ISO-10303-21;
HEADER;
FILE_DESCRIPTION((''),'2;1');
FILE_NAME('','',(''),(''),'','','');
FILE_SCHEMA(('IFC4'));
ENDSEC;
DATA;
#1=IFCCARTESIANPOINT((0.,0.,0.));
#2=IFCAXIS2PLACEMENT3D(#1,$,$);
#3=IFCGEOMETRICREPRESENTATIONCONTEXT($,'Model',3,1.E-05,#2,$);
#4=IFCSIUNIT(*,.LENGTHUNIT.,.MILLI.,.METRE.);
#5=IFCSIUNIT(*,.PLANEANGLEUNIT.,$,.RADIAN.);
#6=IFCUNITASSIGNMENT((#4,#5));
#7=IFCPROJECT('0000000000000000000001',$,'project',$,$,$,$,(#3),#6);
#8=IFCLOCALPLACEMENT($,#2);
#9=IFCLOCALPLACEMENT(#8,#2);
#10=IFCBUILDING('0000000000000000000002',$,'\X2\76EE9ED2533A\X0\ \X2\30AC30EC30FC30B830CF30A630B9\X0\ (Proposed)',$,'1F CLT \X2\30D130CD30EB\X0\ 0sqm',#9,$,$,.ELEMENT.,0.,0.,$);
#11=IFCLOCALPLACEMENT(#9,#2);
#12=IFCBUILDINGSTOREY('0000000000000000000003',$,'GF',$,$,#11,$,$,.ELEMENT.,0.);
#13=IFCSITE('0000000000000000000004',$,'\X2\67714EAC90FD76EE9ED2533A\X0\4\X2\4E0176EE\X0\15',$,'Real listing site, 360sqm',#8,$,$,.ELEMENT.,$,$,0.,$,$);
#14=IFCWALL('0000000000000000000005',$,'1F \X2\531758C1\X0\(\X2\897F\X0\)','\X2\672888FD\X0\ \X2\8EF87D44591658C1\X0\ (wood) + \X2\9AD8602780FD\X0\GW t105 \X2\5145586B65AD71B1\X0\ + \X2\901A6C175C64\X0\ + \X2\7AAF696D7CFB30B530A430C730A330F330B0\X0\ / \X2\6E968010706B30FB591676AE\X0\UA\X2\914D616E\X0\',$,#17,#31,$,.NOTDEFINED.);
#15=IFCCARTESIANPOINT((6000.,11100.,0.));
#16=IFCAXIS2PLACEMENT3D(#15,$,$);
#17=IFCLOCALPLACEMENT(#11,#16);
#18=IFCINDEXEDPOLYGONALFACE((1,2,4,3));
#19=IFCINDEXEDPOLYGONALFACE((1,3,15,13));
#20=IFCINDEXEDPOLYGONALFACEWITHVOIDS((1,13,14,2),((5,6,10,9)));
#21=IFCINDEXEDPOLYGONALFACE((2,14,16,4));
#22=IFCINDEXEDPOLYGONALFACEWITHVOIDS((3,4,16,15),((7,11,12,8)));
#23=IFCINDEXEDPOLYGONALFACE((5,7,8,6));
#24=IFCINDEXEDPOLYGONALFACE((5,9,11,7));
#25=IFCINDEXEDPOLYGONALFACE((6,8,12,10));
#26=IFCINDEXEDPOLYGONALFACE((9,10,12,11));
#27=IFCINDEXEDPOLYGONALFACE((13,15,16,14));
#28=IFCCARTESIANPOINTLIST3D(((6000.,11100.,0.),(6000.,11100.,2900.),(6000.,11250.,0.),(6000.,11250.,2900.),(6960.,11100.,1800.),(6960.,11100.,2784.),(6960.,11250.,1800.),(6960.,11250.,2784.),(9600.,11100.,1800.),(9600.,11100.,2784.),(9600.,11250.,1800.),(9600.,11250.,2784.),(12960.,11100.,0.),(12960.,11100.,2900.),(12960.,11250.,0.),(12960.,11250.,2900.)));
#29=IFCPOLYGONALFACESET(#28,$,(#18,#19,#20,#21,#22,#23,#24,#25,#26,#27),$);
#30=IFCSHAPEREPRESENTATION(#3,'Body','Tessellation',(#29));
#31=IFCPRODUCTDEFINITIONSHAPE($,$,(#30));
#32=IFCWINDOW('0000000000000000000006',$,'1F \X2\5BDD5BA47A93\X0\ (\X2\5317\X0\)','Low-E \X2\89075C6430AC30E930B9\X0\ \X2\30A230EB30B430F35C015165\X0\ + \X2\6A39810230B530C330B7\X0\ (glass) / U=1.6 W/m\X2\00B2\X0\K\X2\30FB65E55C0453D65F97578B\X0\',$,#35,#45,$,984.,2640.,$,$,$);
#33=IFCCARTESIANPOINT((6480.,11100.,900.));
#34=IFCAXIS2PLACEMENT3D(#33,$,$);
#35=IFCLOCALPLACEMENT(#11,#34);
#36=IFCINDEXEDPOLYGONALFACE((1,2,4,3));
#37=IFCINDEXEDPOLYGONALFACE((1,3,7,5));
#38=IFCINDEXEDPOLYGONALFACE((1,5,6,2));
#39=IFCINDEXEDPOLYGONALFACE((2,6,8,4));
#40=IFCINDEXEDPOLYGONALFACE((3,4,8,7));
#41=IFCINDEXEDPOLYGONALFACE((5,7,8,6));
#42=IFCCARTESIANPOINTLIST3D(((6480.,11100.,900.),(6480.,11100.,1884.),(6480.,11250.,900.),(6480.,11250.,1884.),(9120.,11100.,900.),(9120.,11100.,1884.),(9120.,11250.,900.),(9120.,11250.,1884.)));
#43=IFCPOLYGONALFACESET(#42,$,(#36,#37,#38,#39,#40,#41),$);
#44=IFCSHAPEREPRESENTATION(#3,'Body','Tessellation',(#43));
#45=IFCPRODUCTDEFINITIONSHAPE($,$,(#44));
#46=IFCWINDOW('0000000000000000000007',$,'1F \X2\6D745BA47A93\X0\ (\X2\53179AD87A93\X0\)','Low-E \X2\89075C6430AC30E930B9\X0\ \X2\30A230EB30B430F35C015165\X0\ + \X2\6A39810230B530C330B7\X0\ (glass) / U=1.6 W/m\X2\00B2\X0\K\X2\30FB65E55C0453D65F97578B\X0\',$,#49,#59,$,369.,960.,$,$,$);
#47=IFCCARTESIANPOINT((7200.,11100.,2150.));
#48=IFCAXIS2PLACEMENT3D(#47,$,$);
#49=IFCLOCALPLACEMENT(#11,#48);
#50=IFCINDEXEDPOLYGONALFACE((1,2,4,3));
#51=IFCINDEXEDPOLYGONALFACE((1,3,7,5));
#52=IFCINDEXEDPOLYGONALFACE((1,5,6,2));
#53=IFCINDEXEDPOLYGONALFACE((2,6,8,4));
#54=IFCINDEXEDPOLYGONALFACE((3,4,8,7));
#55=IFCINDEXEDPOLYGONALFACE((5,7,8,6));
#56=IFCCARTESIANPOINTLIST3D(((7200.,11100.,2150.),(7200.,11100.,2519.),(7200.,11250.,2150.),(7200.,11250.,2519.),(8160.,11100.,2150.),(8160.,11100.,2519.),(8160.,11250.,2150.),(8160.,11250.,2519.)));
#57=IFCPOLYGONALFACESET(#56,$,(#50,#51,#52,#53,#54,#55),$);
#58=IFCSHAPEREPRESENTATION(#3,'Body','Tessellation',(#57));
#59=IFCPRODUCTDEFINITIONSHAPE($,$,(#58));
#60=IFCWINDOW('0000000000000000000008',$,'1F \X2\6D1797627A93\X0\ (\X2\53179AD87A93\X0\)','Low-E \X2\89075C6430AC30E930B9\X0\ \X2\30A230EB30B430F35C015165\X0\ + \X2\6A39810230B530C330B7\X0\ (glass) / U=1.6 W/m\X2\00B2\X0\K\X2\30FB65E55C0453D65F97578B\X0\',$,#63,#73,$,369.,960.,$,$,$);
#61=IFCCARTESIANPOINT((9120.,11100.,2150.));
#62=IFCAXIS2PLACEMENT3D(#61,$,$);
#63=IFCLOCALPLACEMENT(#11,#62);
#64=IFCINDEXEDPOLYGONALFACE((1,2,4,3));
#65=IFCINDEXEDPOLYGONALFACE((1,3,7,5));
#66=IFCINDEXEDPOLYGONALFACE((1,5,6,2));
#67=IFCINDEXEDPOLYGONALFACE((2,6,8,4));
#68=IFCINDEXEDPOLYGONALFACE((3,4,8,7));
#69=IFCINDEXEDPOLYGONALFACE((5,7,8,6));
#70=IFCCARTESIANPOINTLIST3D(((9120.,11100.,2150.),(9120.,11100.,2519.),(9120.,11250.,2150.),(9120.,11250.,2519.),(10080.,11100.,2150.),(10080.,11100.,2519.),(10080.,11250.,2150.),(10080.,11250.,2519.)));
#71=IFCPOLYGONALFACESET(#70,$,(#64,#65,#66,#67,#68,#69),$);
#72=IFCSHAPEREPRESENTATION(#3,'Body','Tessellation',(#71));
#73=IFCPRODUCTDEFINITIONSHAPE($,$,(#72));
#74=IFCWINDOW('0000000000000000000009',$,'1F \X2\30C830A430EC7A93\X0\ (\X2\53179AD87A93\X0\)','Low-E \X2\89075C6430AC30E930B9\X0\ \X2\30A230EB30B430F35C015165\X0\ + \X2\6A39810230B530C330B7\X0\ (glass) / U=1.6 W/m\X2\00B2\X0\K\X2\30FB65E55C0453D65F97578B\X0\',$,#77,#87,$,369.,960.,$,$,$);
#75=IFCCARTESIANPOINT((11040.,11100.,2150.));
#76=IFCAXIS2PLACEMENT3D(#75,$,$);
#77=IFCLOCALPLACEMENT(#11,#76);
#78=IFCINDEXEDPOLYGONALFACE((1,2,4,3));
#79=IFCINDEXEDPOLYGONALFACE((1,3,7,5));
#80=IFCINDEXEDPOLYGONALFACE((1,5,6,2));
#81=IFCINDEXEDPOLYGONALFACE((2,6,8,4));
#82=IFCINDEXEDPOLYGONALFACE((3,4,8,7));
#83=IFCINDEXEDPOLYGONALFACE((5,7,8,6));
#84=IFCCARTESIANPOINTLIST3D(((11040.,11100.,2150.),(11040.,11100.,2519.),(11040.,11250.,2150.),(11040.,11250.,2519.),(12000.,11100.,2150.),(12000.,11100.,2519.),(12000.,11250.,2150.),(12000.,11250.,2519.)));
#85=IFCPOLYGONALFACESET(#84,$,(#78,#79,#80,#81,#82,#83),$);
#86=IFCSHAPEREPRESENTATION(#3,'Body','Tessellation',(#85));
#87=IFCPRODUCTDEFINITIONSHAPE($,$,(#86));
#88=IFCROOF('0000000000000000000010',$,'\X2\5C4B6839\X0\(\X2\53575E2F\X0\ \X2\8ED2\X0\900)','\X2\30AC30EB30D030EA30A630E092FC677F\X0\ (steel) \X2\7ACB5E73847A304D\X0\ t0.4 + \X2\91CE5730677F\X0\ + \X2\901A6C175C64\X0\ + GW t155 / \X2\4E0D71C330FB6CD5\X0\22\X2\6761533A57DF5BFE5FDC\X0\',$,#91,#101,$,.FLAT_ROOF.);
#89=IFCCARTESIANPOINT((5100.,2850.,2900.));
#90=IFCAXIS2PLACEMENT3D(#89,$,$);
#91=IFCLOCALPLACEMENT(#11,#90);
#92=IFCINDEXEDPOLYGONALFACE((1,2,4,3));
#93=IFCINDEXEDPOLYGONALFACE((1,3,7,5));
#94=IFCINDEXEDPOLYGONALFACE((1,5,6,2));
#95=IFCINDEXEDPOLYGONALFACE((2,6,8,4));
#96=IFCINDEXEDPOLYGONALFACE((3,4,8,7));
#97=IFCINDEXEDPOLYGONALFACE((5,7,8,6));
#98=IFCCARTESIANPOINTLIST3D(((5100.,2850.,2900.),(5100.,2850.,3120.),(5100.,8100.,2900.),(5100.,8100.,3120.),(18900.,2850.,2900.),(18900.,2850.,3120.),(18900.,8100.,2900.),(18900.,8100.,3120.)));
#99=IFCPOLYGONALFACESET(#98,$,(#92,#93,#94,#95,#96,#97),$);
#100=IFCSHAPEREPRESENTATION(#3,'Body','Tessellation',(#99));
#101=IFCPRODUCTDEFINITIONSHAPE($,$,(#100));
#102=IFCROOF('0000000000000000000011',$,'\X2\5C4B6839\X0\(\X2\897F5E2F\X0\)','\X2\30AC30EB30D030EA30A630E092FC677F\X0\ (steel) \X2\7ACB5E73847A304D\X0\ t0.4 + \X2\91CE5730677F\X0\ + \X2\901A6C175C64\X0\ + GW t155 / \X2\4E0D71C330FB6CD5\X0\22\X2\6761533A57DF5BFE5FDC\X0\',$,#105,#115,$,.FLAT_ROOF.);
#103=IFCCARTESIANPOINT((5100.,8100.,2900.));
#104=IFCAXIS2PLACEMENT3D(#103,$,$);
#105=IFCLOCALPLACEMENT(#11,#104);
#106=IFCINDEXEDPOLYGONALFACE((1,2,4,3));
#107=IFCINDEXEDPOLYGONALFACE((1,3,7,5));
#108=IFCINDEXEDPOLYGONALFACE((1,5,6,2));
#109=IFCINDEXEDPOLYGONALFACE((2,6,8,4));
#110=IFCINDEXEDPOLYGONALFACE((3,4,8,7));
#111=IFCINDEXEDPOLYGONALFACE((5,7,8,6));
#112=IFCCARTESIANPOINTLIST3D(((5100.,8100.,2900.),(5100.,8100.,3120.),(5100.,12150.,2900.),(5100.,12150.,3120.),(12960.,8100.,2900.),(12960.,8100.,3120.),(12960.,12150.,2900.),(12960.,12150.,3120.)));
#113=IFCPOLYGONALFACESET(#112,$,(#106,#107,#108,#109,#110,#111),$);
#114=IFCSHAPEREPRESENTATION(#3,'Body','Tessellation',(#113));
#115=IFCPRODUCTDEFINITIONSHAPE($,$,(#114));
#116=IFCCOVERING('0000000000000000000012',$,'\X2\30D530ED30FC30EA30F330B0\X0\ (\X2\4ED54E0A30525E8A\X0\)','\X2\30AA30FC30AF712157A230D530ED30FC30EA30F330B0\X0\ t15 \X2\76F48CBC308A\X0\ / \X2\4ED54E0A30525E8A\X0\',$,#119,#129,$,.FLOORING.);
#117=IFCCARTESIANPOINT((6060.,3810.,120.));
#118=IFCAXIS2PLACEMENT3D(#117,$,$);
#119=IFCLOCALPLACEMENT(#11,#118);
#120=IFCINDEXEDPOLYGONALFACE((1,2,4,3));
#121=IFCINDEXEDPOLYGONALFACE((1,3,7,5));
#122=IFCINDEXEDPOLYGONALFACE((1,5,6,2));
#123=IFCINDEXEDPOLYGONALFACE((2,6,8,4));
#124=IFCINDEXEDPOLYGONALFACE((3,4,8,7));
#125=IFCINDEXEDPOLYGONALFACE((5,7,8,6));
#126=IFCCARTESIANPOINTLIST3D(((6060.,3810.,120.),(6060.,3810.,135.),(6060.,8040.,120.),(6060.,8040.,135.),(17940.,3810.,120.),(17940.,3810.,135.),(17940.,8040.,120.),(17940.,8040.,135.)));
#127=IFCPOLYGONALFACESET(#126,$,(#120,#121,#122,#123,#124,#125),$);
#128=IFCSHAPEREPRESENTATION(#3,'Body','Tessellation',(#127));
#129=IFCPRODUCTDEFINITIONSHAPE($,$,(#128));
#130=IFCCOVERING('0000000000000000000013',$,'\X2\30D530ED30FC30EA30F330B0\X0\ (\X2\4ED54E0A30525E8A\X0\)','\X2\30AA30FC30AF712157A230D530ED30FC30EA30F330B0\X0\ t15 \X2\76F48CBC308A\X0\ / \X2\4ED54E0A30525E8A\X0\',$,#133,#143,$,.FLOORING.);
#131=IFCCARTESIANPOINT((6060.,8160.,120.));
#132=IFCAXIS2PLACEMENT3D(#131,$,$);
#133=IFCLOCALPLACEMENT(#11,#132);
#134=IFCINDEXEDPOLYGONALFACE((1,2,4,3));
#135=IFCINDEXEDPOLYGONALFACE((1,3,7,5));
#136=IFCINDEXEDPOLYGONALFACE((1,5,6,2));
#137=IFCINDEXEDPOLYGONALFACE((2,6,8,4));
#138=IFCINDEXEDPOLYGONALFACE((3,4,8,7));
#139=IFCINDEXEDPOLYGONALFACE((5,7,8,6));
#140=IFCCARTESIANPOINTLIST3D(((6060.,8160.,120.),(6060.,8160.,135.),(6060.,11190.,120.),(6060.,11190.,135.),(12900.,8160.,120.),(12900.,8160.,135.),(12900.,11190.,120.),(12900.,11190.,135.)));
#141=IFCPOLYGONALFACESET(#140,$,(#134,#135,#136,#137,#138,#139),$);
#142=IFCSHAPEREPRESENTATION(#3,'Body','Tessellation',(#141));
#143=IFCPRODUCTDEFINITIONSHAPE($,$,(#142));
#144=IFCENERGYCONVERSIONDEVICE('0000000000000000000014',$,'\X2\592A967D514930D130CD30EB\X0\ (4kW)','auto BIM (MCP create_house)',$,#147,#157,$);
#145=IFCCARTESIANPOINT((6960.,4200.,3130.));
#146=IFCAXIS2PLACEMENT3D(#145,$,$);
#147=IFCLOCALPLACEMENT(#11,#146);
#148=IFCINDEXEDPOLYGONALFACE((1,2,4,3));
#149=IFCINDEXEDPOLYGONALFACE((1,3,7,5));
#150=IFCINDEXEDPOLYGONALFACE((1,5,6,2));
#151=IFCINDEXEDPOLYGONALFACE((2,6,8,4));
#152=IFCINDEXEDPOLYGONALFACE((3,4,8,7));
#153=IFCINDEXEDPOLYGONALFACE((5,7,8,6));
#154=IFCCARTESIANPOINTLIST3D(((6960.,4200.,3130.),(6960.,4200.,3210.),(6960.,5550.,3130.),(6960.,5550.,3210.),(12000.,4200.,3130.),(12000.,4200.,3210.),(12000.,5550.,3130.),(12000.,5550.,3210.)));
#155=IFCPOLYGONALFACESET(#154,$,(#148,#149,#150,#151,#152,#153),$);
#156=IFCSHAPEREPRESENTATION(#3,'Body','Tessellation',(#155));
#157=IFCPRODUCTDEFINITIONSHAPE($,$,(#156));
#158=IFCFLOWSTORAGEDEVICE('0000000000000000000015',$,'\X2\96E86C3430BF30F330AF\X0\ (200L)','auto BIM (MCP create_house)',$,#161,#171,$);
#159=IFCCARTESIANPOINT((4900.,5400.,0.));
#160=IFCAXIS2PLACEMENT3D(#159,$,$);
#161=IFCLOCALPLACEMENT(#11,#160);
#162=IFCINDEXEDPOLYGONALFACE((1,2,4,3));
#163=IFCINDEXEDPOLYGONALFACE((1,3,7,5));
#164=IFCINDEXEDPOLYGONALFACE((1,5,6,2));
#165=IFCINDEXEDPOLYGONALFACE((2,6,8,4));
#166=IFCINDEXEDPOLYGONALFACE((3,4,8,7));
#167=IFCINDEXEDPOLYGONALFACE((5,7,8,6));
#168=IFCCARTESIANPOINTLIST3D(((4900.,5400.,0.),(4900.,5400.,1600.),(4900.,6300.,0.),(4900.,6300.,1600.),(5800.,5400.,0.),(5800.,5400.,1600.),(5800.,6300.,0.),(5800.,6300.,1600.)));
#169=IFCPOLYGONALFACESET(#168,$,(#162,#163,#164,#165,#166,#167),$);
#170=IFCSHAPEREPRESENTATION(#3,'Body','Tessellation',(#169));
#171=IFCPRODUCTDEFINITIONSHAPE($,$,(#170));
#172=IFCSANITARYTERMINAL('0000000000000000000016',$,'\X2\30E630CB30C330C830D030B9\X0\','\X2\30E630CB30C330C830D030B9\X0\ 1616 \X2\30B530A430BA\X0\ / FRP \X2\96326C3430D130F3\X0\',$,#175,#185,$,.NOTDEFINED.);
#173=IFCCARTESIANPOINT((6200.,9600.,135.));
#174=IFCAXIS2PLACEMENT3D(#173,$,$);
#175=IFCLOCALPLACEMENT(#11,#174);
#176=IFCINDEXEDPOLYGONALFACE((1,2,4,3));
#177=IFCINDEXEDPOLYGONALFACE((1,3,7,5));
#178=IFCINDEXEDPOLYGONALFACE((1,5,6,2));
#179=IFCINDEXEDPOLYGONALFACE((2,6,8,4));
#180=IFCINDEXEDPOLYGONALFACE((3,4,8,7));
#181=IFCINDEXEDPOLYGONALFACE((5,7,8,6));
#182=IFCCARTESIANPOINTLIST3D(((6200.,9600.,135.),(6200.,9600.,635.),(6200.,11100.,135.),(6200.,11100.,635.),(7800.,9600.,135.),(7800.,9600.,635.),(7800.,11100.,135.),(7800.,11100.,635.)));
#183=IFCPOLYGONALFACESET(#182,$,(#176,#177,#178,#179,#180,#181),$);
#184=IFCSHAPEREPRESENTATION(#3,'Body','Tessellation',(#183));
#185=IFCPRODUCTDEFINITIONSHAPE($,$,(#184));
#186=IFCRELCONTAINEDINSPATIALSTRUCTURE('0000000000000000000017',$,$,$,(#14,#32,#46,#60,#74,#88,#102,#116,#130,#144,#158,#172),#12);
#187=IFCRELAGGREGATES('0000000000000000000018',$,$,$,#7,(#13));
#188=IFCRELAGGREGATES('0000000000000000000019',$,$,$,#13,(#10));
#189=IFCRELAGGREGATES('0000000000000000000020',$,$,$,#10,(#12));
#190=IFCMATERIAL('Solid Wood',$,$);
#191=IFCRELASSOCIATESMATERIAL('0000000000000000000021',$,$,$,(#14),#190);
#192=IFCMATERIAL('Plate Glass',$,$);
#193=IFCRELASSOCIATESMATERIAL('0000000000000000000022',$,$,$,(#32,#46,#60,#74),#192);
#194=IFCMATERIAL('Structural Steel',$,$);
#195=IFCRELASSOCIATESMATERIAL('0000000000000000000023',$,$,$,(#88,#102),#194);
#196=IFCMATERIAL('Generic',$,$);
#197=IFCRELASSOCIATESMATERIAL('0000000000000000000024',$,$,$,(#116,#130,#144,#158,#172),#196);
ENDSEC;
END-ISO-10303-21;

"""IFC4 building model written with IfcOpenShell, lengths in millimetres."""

from ifc_helpers import new_model, si_unit, frame, frame_2d, origin, place, context, project, spatial, rectangle, extrude, material, element, fill, save


model = new_model("IFC4")

# Units and contexts
model_context = context("Model", 3, precision=1e-05, world=origin())
ifc_project = project(units=[si_unit("LENGTHUNIT", "METRE", prefix="MILLI"), si_unit("PLANEANGLEUNIT", "RADIAN")], contexts=[model_context])

# Site, building, storey
site_placement = place(None, origin())
site = spatial("IfcSite", under=ifc_project, at=site_placement, Name="東京都目黒区4丁目15", ObjectType="Real listing site, 360sqm", CompositionType="ELEMENT", RefElevation=0.0)
building_placement = place(site_placement, origin())
building = spatial("IfcBuilding", under=site, at=building_placement, Name="目黒区 ガレージハウス (Proposed)", ObjectType="1F CLT パネル 0sqm", CompositionType="ELEMENT", ElevationOfRefHeight=0.0, ElevationOfTerrain=0.0)
storey_placement = place(building_placement, origin())
storey = spatial("IfcBuildingStorey", under=building, at=storey_placement, Name="GF", CompositionType="ELEMENT", Elevation=0.0)

# Shared definitions
ifc_material_1 = material(Name="Solid Wood")

# Shared definitions
ifc_material_2 = material(Name="Plate Glass")

# Wall, openings, windows
wall_1_placement = place(storey_placement, frame((6000.0, 11100.0, 0.0)))
wall_1 = element("IfcWall", 1, at=wall_1_placement, inside=storey, material=ifc_material_1, Name="1F 北壁(西)", Description="木製 軸組外壁 (wood) + 高性能GW t105 充填断熱 + 通気層 + 窯業系サイディング / 準耐火・外皮UA配慮", PredefinedType="NOTDEFINED", context=model_context, shape_type="SweptSolid", body=[
    extrude(rectangle(XDim=6960.0, YDim=150.0, at=frame_2d((3480.0, 75.0))), frame((6000.0, 11100.0, 0.0)), (0.0, 0.0, 1.0), 2900.0),
])
opening_1_placement = place(storey_placement, frame((6480.0, 11100.0, 900.0)))
opening_1 = element("IfcOpeningElement", 2, at=opening_1_placement, cuts=wall_1, PredefinedType="NOTDEFINED", context=model_context, shape_type="SweptSolid", body=[
    extrude(rectangle(XDim=2640.0, YDim=150.0, at=frame_2d((1320.0, 75.0))), frame((6480.0, 11100.0, 900.0)), (0.0, 0.0, 1.0), 984.0),
])
opening_2_placement = place(storey_placement, frame((7200.0, 11100.0, 2150.0)))
opening_2 = element("IfcOpeningElement", 3, at=opening_2_placement, cuts=wall_1, PredefinedType="NOTDEFINED", context=model_context, shape_type="SweptSolid", body=[
    extrude(rectangle(XDim=960.0, YDim=150.0, at=frame_2d((480.0, 75.0))), frame((7200.0, 11100.0, 2150.0)), (0.0, 0.0, 1.0), 369.0),
])
opening_3_placement = place(storey_placement, frame((9120.0, 11100.0, 2150.0)))
opening_3 = element("IfcOpeningElement", 4, at=opening_3_placement, cuts=wall_1, PredefinedType="NOTDEFINED", context=model_context, shape_type="SweptSolid", body=[
    extrude(rectangle(XDim=960.0, YDim=150.0, at=frame_2d((480.0, 75.0))), frame((9120.0, 11100.0, 2150.0)), (0.0, 0.0, 1.0), 369.0),
])
opening_4_placement = place(storey_placement, frame((11040.0, 11100.0, 2150.0)))
opening_4 = element("IfcOpeningElement", 5, at=opening_4_placement, cuts=wall_1, PredefinedType="NOTDEFINED", context=model_context, shape_type="SweptSolid", body=[
    extrude(rectangle(XDim=960.0, YDim=150.0, at=frame_2d((480.0, 75.0))), frame((11040.0, 11100.0, 2150.0)), (0.0, 0.0, 1.0), 369.0),
])
window_1_placement = place(storey_placement, frame((6480.0, 11100.0, 900.0)))
window_1 = element("IfcWindow", 6, at=window_1_placement, inside=storey, material=ifc_material_2, Name="1F 寝室窓 (北)", Description="Low-E 複層ガラス アルゴン封入 + 樹脂サッシ (glass) / U=1.6 W/m²K・日射取得型", OverallHeight=984.0, OverallWidth=2640.0, context=model_context, shape_type="SweptSolid", body=[
    extrude(rectangle(XDim=2640.0, YDim=150.0, at=frame_2d((1320.0, 75.0))), frame((6480.0, 11100.0, 900.0)), (0.0, 0.0, 1.0), 984.0),
])
fill(opening_1, window_1)
window_2_placement = place(storey_placement, frame((7200.0, 11100.0, 2150.0)))
window_2 = element("IfcWindow", 7, at=window_2_placement, inside=storey, material=ifc_material_2, Name="1F 浴室窓 (北高窓)", Description="Low-E 複層ガラス アルゴン封入 + 樹脂サッシ (glass) / U=1.6 W/m²K・日射取得型", OverallHeight=369.0, OverallWidth=960.0, context=model_context, shape_type="SweptSolid", body=[
    extrude(rectangle(XDim=960.0, YDim=150.0, at=frame_2d((480.0, 75.0))), frame((7200.0, 11100.0, 2150.0)), (0.0, 0.0, 1.0), 369.0),
])
fill(opening_2, window_2)
window_3_placement = place(storey_placement, frame((9120.0, 11100.0, 2150.0)))
window_3 = element("IfcWindow", 8, at=window_3_placement, inside=storey, material=ifc_material_2, Name="1F 洗面窓 (北高窓)", Description="Low-E 複層ガラス アルゴン封入 + 樹脂サッシ (glass) / U=1.6 W/m²K・日射取得型", OverallHeight=369.0, OverallWidth=960.0, context=model_context, shape_type="SweptSolid", body=[
    extrude(rectangle(XDim=960.0, YDim=150.0, at=frame_2d((480.0, 75.0))), frame((9120.0, 11100.0, 2150.0)), (0.0, 0.0, 1.0), 369.0),
])
fill(opening_3, window_3)
window_4_placement = place(storey_placement, frame((11040.0, 11100.0, 2150.0)))
window_4 = element("IfcWindow", 9, at=window_4_placement, inside=storey, material=ifc_material_2, Name="1F トイレ窓 (北高窓)", Description="Low-E 複層ガラス アルゴン封入 + 樹脂サッシ (glass) / U=1.6 W/m²K・日射取得型", OverallHeight=369.0, OverallWidth=960.0, context=model_context, shape_type="SweptSolid", body=[
    extrude(rectangle(XDim=960.0, YDim=150.0, at=frame_2d((480.0, 75.0))), frame((11040.0, 11100.0, 2150.0)), (0.0, 0.0, 1.0), 369.0),
])
fill(opening_4, window_4)

# Roofs
ifc_material_3 = material(Name="Structural Steel")
roof_1_placement = place(storey_placement, frame((5100.0, 2850.0, 2900.0)))
element("IfcRoof", 10, at=roof_1_placement, inside=storey, material=ifc_material_3, Name="屋根(南帯 軒900)", Description="ガルバリウム鋼板 (steel) 立平葺き t0.4 + 野地板 + 通気層 + GW t155 / 不燃・法22条区域対応", PredefinedType="FLAT_ROOF", context=model_context, shape_type="SweptSolid", body=[
    extrude(rectangle(XDim=13800.0, YDim=5250.0, at=frame_2d((6900.0, 2625.0))), frame((5100.0, 2850.0, 2900.0)), (0.0, 0.0, 1.0), 220.0),
])
roof_2_placement = place(storey_placement, frame((5100.0, 8100.0, 2900.0)))
element("IfcRoof", 11, at=roof_2_placement, inside=storey, material=ifc_material_3, Name="屋根(西帯)", Description="ガルバリウム鋼板 (steel) 立平葺き t0.4 + 野地板 + 通気層 + GW t155 / 不燃・法22条区域対応", PredefinedType="FLAT_ROOF", context=model_context, shape_type="SweptSolid", body=[
    extrude(rectangle(XDim=7860.0, YDim=4050.0, at=frame_2d((3930.0, 2025.0))), frame((5100.0, 8100.0, 2900.0)), (0.0, 0.0, 1.0), 220.0),
])

# Coverings
ifc_material_4 = material(Name="Generic")
covering_1_placement = place(storey_placement, frame((6060.0, 3810.0, 120.0)))
element("IfcCovering", 12, at=covering_1_placement, inside=storey, material=ifc_material_4, Name="フローリング (仕上げ床)", Description="オーク無垢フローリング t15 直貼り / 仕上げ床", PredefinedType="FLOORING", context=model_context, shape_type="SweptSolid", body=[
    extrude(rectangle(XDim=11880.0, YDim=4230.0, at=frame_2d((5940.0, 2115.0))), frame((6060.0, 3810.0, 120.0)), (0.0, 0.0, 1.0), 15.0),
])
covering_2_placement = place(storey_placement, frame((6060.0, 8160.0, 120.0)))
element("IfcCovering", 13, at=covering_2_placement, inside=storey, material=ifc_material_4, Name="フローリング (仕上げ床)", Description="オーク無垢フローリング t15 直貼り / 仕上げ床", PredefinedType="FLOORING", context=model_context, shape_type="SweptSolid", body=[
    extrude(rectangle(XDim=6840.0, YDim=3030.0, at=frame_2d((3420.0, 1515.0))), frame((6060.0, 8160.0, 120.0)), (0.0, 0.0, 1.0), 15.0),
])

# Energy conversion device
energy_conversion_device_placement = place(storey_placement, frame((6960.0, 4200.0, 3130.0)))
element("IfcEnergyConversionDevice", 14, at=energy_conversion_device_placement, inside=storey, material=ifc_material_4, Name="太陽光パネル (4kW)", Description="auto BIM (MCP create_house)", context=model_context, shape_type="SweptSolid", body=[
    extrude(rectangle(XDim=5040.0, YDim=1350.0, at=frame_2d((2520.0, 675.0))), frame((6960.0, 4200.0, 3130.0)), (0.0, 0.0, 1.0), 80.0),
])

# Flow storage device
flow_storage_device_placement = place(storey_placement, frame((4900.0, 5400.0, 0.0)))
element("IfcFlowStorageDevice", 15, at=flow_storage_device_placement, inside=storey, material=ifc_material_4, Name="雨水タンク (200L)", Description="auto BIM (MCP create_house)", context=model_context, shape_type="SweptSolid", body=[
    extrude(rectangle(XDim=900.0, YDim=900.0, at=frame_2d((450.0, 450.0))), frame((4900.0, 5400.0, 0.0)), (0.0, 0.0, 1.0), 1600.0),
])

# Sanitary terminal
sanitary_terminal_placement = place(storey_placement, frame((6200.0, 9600.0, 135.0)))
element("IfcSanitaryTerminal", 16, at=sanitary_terminal_placement, inside=storey, material=ifc_material_4, Name="ユニットバス", Description="ユニットバス 1616 サイズ / FRP 防水パン", PredefinedType="NOTDEFINED", context=model_context, shape_type="SweptSolid", body=[
    extrude(rectangle(XDim=1600.0, YDim=1500.0, at=frame_2d((800.0, 750.0))), frame((6200.0, 9600.0, 135.0)), (0.0, 0.0, 1.0), 500.0),
])

save(model, "model.ifc")
